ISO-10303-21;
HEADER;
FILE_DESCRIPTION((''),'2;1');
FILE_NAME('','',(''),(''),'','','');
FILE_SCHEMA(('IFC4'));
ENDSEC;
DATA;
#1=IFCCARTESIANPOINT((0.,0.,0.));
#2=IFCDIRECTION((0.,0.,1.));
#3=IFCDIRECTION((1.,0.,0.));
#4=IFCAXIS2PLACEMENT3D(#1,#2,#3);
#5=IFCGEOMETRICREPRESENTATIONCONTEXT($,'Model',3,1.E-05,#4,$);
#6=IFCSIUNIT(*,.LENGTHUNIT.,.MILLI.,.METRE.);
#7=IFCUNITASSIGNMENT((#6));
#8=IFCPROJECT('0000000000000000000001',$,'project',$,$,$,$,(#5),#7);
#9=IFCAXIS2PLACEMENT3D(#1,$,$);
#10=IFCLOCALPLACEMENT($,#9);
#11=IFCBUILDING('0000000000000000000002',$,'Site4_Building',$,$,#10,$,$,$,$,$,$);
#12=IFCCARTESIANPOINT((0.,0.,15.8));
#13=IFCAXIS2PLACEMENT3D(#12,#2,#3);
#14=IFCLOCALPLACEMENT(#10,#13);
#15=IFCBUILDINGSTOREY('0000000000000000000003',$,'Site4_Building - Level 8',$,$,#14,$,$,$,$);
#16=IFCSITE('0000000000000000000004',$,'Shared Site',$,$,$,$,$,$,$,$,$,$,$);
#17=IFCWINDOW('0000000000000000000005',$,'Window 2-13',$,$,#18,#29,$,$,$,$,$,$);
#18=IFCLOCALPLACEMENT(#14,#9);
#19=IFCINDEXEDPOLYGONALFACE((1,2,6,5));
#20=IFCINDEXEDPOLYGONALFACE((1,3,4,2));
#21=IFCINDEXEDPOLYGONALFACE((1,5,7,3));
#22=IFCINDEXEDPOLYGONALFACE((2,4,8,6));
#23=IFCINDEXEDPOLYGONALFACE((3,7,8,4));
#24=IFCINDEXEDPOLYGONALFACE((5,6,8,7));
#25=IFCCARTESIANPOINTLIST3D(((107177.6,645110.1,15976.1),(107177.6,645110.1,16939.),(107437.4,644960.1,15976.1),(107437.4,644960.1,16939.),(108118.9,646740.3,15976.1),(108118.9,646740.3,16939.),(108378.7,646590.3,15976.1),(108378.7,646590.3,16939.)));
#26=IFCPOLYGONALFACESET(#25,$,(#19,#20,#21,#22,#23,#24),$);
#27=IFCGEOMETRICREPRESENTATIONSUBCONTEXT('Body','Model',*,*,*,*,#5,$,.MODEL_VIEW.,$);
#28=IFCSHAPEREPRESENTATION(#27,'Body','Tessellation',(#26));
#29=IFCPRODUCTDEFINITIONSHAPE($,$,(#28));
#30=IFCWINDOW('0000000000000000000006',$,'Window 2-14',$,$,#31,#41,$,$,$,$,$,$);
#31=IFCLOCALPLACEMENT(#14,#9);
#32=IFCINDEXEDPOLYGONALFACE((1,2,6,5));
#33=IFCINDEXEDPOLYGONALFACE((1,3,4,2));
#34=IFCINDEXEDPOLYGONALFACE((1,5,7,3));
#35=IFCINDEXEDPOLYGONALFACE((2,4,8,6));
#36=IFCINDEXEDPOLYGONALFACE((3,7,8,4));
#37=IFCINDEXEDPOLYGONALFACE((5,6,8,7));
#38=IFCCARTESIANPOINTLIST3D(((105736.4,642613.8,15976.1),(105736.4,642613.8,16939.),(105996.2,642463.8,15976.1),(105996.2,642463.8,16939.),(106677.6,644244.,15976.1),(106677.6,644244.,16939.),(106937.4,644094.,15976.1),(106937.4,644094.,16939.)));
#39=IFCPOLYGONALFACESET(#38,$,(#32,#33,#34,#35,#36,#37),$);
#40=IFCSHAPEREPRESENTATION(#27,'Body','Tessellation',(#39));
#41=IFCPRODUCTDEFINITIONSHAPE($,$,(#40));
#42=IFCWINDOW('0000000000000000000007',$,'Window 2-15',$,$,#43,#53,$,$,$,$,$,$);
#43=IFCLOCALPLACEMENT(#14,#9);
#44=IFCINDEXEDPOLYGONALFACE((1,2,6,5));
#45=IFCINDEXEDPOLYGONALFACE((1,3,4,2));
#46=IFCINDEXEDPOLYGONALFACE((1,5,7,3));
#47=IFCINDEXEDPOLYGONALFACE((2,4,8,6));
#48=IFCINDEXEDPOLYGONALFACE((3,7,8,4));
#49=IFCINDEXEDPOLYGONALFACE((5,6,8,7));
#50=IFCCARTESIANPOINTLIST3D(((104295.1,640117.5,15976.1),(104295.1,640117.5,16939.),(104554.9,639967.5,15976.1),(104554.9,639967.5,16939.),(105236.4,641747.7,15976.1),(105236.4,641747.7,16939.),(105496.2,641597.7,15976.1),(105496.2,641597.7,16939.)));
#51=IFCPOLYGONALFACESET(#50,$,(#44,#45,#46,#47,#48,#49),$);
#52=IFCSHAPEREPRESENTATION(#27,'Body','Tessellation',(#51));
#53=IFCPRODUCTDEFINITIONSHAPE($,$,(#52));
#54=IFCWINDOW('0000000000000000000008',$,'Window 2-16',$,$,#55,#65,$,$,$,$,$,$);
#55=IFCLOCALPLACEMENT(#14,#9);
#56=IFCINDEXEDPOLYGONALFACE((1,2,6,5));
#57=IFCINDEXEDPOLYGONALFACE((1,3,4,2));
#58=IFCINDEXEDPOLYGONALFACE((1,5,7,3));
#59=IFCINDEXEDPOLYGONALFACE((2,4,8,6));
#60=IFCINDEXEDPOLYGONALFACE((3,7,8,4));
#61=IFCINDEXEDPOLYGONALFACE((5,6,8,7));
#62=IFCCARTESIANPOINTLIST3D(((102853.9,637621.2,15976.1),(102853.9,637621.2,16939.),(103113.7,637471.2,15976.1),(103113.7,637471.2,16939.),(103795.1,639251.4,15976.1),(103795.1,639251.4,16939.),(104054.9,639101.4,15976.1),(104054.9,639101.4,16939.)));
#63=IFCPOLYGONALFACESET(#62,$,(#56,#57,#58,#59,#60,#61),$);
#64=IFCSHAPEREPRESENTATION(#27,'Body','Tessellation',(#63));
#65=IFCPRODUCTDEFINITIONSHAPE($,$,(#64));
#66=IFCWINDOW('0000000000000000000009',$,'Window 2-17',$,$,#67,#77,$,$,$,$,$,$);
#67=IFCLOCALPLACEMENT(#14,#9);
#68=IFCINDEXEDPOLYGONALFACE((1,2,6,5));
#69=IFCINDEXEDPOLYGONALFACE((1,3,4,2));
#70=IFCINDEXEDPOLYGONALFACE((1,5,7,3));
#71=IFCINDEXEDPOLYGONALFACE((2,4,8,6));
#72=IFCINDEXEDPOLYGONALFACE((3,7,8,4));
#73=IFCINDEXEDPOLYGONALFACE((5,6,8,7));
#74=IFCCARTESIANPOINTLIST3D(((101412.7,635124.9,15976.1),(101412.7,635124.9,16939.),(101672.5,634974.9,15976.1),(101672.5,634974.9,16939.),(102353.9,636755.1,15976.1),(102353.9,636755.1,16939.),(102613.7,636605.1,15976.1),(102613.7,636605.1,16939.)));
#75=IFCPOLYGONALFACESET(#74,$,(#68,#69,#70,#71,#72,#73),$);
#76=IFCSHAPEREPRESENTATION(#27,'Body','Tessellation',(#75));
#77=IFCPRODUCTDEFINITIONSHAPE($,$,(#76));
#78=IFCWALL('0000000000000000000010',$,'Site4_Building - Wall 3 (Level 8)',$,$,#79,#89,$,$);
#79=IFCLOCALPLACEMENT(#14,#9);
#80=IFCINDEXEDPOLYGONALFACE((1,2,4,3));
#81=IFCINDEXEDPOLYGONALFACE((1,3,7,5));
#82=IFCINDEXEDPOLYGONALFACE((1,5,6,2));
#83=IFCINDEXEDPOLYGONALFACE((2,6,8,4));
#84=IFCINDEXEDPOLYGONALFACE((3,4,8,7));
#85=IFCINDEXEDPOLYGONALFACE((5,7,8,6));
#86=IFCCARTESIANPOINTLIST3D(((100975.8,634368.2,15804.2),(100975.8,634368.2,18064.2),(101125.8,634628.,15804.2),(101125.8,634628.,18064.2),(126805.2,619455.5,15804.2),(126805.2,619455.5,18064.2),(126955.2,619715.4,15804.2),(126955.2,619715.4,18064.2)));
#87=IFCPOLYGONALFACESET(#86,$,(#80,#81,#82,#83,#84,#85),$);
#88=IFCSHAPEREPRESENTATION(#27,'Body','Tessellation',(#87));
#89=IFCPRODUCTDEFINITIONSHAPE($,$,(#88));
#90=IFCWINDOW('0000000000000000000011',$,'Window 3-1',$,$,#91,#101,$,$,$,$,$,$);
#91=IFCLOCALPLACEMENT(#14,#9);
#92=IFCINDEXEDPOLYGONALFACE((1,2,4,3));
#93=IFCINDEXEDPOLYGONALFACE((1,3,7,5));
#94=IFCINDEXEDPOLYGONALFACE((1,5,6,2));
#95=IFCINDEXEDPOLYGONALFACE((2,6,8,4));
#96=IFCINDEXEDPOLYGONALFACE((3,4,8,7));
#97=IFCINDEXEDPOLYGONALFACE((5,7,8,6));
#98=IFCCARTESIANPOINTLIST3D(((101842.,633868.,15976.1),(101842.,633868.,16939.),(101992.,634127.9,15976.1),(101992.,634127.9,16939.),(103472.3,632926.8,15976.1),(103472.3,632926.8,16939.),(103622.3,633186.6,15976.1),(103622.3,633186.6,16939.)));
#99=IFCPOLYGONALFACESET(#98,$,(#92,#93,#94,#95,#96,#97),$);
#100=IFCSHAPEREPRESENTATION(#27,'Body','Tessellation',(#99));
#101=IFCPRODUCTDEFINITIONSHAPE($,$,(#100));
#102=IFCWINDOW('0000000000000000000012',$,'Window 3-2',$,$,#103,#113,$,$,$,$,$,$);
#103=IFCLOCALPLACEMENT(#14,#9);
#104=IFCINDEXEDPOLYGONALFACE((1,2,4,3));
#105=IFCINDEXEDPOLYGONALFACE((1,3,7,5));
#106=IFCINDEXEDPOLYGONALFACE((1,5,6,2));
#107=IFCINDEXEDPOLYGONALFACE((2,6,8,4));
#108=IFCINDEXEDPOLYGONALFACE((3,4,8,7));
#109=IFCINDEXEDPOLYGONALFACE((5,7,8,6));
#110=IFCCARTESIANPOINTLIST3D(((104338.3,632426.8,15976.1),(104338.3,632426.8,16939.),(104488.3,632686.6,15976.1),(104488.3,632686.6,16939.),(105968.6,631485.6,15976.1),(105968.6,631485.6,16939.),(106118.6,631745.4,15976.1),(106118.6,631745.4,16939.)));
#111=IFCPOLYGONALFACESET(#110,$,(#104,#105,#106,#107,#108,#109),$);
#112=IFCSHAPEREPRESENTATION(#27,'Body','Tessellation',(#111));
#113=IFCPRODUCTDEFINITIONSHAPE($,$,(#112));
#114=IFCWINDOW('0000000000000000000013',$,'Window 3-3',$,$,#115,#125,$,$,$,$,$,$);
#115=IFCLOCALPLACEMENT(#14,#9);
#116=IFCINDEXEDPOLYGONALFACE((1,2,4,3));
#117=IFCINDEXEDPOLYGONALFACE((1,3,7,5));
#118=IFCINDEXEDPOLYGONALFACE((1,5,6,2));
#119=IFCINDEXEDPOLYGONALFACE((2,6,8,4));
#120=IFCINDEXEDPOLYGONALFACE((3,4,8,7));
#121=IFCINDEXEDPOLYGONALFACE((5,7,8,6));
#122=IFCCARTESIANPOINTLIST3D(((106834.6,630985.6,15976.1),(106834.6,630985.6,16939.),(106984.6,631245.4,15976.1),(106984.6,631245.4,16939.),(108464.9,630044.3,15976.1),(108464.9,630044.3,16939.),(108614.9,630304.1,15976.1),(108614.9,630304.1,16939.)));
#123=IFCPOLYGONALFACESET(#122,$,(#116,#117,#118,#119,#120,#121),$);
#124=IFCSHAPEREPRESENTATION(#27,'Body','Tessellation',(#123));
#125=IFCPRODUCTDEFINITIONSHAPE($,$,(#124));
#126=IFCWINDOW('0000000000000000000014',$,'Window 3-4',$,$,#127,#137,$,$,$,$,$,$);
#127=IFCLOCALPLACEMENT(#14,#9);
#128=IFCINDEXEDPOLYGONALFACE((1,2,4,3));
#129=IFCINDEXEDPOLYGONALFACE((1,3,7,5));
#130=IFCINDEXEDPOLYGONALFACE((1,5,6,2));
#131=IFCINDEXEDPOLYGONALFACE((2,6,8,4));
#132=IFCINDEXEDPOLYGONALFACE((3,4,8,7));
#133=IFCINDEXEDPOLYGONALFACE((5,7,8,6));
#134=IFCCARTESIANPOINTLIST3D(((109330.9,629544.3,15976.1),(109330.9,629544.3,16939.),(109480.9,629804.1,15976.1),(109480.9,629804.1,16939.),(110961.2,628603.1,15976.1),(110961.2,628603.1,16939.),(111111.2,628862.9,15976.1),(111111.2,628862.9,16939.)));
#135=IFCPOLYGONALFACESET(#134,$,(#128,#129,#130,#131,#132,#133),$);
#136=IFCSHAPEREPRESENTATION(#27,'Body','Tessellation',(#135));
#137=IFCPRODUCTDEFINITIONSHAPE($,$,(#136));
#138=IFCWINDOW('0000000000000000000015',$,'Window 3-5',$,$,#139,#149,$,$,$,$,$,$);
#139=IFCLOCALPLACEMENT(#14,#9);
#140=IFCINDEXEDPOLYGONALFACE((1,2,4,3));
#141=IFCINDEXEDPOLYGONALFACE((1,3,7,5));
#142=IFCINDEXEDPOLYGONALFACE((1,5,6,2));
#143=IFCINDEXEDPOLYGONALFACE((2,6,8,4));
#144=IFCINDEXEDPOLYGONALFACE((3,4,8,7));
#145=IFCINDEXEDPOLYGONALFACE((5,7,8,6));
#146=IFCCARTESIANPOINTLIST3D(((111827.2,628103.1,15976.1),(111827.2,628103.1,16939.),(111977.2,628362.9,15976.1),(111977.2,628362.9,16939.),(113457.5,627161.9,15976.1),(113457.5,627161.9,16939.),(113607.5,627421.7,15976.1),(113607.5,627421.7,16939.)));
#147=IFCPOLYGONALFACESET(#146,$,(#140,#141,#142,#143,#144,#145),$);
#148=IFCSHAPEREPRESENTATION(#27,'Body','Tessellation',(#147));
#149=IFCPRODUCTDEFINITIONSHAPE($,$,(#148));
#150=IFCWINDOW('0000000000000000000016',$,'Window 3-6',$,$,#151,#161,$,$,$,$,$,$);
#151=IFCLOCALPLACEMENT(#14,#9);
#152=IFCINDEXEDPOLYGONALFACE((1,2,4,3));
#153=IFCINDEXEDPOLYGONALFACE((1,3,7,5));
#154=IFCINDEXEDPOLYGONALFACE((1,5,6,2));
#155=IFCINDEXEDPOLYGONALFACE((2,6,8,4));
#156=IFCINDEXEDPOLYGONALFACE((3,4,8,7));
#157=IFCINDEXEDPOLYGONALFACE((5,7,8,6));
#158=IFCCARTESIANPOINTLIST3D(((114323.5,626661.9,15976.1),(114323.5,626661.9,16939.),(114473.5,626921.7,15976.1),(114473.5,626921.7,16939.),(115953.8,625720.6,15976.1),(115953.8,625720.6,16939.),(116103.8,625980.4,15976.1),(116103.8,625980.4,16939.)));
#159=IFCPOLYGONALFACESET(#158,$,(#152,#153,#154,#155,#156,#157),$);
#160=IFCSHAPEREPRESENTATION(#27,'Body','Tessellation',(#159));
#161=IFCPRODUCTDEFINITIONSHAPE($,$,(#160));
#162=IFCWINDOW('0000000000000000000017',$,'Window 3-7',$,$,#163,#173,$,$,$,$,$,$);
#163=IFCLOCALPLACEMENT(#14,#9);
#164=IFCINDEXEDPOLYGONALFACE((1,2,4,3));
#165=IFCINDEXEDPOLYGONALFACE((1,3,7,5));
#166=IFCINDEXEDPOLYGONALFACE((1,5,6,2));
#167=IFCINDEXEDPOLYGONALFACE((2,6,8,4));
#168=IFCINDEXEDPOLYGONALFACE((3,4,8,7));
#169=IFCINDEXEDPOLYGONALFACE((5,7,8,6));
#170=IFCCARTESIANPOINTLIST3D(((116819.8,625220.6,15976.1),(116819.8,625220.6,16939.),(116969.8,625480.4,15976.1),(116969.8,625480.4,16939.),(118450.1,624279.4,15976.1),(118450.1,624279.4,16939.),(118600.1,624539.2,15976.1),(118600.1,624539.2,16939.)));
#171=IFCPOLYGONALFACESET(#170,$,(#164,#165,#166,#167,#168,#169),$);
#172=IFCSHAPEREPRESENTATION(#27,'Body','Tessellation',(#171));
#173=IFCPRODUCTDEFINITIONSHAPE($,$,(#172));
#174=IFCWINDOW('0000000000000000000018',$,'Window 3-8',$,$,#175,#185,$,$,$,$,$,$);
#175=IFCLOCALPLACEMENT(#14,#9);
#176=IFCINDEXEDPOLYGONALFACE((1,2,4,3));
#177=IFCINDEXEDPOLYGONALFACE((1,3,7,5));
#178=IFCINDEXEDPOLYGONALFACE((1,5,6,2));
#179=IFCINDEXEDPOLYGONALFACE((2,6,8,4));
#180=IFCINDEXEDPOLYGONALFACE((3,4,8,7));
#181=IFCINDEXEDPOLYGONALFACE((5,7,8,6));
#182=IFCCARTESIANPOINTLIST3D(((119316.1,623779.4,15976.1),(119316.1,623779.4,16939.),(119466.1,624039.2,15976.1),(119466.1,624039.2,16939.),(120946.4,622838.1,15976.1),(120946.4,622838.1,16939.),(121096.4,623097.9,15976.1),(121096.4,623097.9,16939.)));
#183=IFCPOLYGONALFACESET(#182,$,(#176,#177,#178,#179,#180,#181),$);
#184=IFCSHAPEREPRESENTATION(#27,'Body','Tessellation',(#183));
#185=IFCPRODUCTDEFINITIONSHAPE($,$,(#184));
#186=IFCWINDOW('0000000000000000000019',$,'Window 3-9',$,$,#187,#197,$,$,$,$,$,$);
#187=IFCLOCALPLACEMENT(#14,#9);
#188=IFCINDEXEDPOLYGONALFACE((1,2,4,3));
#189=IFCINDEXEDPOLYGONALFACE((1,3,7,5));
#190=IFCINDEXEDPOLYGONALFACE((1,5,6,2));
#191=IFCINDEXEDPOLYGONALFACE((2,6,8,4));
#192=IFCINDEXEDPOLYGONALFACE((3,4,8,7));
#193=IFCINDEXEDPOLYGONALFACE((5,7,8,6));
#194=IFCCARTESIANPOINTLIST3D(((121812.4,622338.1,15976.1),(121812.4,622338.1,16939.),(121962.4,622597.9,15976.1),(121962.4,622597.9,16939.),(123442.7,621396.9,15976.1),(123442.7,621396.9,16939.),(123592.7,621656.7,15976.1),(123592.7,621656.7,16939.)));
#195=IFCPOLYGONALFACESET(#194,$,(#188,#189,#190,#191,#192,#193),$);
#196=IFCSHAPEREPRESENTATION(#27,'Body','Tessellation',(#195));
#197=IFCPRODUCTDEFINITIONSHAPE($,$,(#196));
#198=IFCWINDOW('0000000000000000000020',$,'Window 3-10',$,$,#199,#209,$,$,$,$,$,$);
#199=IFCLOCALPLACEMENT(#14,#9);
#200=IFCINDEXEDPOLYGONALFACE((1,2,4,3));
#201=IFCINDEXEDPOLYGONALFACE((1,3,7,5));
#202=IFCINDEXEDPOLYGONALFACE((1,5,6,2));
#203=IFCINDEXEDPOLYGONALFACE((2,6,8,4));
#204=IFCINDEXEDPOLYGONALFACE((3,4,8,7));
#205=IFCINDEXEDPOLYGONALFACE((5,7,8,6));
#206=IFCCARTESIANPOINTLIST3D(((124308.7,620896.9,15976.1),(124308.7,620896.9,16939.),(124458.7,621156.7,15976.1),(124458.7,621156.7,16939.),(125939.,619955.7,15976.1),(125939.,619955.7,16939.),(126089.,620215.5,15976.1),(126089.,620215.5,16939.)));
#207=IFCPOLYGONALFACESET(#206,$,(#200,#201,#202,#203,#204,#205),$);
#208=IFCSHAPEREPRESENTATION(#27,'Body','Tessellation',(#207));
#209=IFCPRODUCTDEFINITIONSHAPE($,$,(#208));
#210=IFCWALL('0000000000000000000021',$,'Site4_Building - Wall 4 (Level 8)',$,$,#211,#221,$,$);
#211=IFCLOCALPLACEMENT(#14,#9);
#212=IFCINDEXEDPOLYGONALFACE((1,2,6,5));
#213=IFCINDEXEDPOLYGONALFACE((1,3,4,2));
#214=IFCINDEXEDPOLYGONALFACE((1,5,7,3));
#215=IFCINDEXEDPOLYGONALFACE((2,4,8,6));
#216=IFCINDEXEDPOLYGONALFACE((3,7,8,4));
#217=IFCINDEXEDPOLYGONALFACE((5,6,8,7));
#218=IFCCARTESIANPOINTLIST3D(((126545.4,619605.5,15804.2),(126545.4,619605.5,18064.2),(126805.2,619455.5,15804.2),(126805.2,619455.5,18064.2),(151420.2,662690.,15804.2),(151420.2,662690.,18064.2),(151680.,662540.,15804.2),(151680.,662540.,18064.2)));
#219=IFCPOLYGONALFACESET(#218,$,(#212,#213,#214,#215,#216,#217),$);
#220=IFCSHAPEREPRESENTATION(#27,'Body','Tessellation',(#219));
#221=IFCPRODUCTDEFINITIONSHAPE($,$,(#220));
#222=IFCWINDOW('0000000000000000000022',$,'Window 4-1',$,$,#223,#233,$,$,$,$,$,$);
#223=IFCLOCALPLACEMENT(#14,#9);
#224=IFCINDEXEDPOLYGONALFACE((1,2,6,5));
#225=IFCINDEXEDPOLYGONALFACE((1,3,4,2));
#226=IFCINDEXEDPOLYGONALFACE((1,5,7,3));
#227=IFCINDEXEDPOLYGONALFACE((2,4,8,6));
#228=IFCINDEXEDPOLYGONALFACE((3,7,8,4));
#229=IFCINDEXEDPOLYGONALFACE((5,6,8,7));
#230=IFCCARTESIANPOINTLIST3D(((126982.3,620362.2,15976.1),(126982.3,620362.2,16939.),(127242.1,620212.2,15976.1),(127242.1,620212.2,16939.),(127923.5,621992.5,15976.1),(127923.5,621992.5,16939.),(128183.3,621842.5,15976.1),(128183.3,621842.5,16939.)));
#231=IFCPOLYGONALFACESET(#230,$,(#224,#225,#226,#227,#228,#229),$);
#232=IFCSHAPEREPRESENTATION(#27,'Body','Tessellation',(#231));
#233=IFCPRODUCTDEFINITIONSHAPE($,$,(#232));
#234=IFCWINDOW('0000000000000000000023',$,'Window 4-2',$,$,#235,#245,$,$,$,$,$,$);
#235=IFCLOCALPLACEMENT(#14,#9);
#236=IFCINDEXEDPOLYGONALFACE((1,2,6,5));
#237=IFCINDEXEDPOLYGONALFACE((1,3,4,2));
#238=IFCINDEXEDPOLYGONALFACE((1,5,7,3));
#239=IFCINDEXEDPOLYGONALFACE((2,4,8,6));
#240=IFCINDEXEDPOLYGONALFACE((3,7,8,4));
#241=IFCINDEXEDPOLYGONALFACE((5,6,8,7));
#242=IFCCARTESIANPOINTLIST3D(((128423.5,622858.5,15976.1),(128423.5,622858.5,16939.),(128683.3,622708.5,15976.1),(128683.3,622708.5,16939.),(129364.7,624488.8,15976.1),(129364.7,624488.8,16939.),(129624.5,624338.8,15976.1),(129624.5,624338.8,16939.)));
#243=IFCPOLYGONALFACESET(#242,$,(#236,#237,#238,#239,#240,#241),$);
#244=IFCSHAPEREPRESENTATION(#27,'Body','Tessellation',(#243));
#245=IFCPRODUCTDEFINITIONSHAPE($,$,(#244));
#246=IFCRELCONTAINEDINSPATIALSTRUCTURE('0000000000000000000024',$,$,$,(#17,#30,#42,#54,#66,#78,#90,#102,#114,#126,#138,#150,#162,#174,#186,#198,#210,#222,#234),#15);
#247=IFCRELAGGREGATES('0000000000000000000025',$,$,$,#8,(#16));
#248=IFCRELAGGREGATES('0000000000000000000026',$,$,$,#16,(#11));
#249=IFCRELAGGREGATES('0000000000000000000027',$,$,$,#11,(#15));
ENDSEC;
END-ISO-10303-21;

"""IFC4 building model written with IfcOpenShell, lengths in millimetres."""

from ifc_helpers import new_model, si_unit, frame, origin, origin_with_axes, place, context, subcontext, project, spatial, indexed_curve, outline, extrude, element, save


model = new_model("IFC4")

# Units and contexts
model_context = context("Model", 3, precision=1e-05, world=origin_with_axes())
body_context = subcontext(model_context, "Body", "Model", "MODEL_VIEW")
ifc_project = project(units=[si_unit("LENGTHUNIT", "METRE", prefix="MILLI")], contexts=[model_context])

# Site, building, storey
site = spatial("IfcSite", under=ifc_project, Name="Shared Site")
building_placement = place(None, origin())
building = spatial("IfcBuilding", under=site, at=building_placement, Name="Site4_Building")
storey_placement = place(building_placement, frame((0.0, 0.0, 15.8), z_axis=(0.0, 0.0, 1.0), x_axis=(1.0, 0.0, 0.0)))
storey = spatial("IfcBuildingStorey", under=building, at=storey_placement, Name="Site4_Building - Level 8")

# Windows
for number, where, z_axis, x_axis, name in (
    (1, (108118.9, 646740.3, 15976.1), (0.0, 0.0, 1.0), (-0.5, -0.866025, 0.0), "Window 2-13"),
    (2, (106677.6, 644244.0, 15976.1), (0.0, 0.0, 1.0), (-0.5, -0.866025, 0.0), "Window 2-14"),
    (3, (105236.4, 641747.7, 15976.1), (0.0, 0.0, 1.0), (-0.5, -0.866025, 0.0), "Window 2-15"),
    (4, (103795.1, 639251.4, 15976.1), (0.0, 0.0, 1.0), (-0.5, -0.866025, 0.0), "Window 2-16"),
    (5, (102353.9, 636755.1, 15976.1), (0.0, 0.0, 1.0), (-0.5, -0.866025, 0.0), "Window 2-17"),
):
    element("IfcWindow", number, at=place(storey_placement, frame(where, z_axis=z_axis, x_axis=x_axis)), inside=storey, Name=name, context=body_context, shape_type="SweptSolid", body=[
        extrude(outline(indexed_curve([(0.0, 0.0), (0.0, 300.0), (1882.5, 300.0), (1882.5, 0.0), (0.0, 0.0)], self_intersect=False)), origin_with_axes(), (0.0, 0.0, 1.0), 962.8),
    ])

# Wall
wall_1_placement = place(storey_placement, frame((100975.8, 634368.2, 15804.2), z_axis=(0.0, 0.0, 1.0), x_axis=(0.866025, -0.5, 0.0)))
element("IfcWall", 6, at=wall_1_placement, inside=storey, Name="Site4_Building - Wall 3 (Level 8)", context=body_context, shape_type="SweptSolid", body=[
    extrude(outline(indexed_curve([(0.0, 0.0), (0.0, 300.0), (29825.2, 300.0), (29825.2, 0.0), (0.0, 0.0)], self_intersect=False)), origin_with_axes(), (0.0, 0.0, 1.0), 2260.0),
])

# Windows
for number, where, z_axis, x_axis, name in (
    (7, (101842.0, 633868.0, 15976.1), (0.0, 0.0, 1.0), (0.866025, -0.5, 0.0), "Window 3-1"),
    (8, (104338.3, 632426.8, 15976.1), (0.0, 0.0, 1.0), (0.866025, -0.5, 0.0), "Window 3-2"),
    (9, (106834.6, 630985.6, 15976.1), (0.0, 0.0, 1.0), (0.866025, -0.5, 0.0), "Window 3-3"),
    (10, (109330.9, 629544.3, 15976.1), (0.0, 0.0, 1.0), (0.866025, -0.5, 0.0), "Window 3-4"),
    (11, (111827.2, 628103.1, 15976.1), (0.0, 0.0, 1.0), (0.866025, -0.5, 0.0), "Window 3-5"),
    (12, (114323.5, 626661.9, 15976.1), (0.0, 0.0, 1.0), (0.866025, -0.5, 0.0), "Window 3-6"),
    (13, (116819.8, 625220.6, 15976.1), (0.0, 0.0, 1.0), (0.866025, -0.5, 0.0), "Window 3-7"),
    (14, (119316.1, 623779.4, 15976.1), (0.0, 0.0, 1.0), (0.866025, -0.5, 0.0), "Window 3-8"),
    (15, (121812.4, 622338.1, 15976.1), (0.0, 0.0, 1.0), (0.866025, -0.5, 0.0), "Window 3-9"),
    (16, (124308.7, 620896.9, 15976.1), (0.0, 0.0, 1.0), (0.866025, -0.5, 0.0), "Window 3-10"),
):
    element("IfcWindow", number, at=place(storey_placement, frame(where, z_axis=z_axis, x_axis=x_axis)), inside=storey, Name=name, context=body_context, shape_type="SweptSolid", body=[
        extrude(outline(indexed_curve([(0.0, 0.0), (0.0, 300.0), (1882.5, 300.0), (1882.5, 0.0), (0.0, 0.0)], self_intersect=False)), origin_with_axes(), (0.0, 0.0, 1.0), 962.8),
    ])

# Wall
wall_2_placement = place(storey_placement, frame((126805.2, 619455.5, 15804.2), z_axis=(0.0, 0.0, 1.0), x_axis=(0.5, 0.866025, 0.0)))
element("IfcWall", 17, at=wall_2_placement, inside=storey, Name="Site4_Building - Wall 4 (Level 8)", context=body_context, shape_type="SweptSolid", body=[
    extrude(outline(indexed_curve([(0.0, 0.0), (0.0, 300.0), (49749.6, 300.0), (49749.6, 0.0), (0.0, 0.0)], self_intersect=False)), origin_with_axes(), (0.0, 0.0, 1.0), 2260.0),
])

# Windows
for number, where, z_axis, x_axis, name in (
    (18, (127242.1, 620212.2, 15976.1), (0.0, 0.0, 1.0), (0.5, 0.866025, 0.0), "Window 4-1"),
    (19, (128683.3, 622708.5, 15976.1), (0.0, 0.0, 1.0), (0.5, 0.866025, 0.0), "Window 4-2"),
):
    element("IfcWindow", number, at=place(storey_placement, frame(where, z_axis=z_axis, x_axis=x_axis)), inside=storey, Name=name, context=body_context, shape_type="SweptSolid", body=[
        extrude(outline(indexed_curve([(0.0, 0.0), (0.0, 300.0), (1882.5, 300.0), (1882.5, 0.0), (0.0, 0.0)], self_intersect=False)), origin_with_axes(), (0.0, 0.0, 1.0), 962.8),
    ])

save(model, "model.ifc")
